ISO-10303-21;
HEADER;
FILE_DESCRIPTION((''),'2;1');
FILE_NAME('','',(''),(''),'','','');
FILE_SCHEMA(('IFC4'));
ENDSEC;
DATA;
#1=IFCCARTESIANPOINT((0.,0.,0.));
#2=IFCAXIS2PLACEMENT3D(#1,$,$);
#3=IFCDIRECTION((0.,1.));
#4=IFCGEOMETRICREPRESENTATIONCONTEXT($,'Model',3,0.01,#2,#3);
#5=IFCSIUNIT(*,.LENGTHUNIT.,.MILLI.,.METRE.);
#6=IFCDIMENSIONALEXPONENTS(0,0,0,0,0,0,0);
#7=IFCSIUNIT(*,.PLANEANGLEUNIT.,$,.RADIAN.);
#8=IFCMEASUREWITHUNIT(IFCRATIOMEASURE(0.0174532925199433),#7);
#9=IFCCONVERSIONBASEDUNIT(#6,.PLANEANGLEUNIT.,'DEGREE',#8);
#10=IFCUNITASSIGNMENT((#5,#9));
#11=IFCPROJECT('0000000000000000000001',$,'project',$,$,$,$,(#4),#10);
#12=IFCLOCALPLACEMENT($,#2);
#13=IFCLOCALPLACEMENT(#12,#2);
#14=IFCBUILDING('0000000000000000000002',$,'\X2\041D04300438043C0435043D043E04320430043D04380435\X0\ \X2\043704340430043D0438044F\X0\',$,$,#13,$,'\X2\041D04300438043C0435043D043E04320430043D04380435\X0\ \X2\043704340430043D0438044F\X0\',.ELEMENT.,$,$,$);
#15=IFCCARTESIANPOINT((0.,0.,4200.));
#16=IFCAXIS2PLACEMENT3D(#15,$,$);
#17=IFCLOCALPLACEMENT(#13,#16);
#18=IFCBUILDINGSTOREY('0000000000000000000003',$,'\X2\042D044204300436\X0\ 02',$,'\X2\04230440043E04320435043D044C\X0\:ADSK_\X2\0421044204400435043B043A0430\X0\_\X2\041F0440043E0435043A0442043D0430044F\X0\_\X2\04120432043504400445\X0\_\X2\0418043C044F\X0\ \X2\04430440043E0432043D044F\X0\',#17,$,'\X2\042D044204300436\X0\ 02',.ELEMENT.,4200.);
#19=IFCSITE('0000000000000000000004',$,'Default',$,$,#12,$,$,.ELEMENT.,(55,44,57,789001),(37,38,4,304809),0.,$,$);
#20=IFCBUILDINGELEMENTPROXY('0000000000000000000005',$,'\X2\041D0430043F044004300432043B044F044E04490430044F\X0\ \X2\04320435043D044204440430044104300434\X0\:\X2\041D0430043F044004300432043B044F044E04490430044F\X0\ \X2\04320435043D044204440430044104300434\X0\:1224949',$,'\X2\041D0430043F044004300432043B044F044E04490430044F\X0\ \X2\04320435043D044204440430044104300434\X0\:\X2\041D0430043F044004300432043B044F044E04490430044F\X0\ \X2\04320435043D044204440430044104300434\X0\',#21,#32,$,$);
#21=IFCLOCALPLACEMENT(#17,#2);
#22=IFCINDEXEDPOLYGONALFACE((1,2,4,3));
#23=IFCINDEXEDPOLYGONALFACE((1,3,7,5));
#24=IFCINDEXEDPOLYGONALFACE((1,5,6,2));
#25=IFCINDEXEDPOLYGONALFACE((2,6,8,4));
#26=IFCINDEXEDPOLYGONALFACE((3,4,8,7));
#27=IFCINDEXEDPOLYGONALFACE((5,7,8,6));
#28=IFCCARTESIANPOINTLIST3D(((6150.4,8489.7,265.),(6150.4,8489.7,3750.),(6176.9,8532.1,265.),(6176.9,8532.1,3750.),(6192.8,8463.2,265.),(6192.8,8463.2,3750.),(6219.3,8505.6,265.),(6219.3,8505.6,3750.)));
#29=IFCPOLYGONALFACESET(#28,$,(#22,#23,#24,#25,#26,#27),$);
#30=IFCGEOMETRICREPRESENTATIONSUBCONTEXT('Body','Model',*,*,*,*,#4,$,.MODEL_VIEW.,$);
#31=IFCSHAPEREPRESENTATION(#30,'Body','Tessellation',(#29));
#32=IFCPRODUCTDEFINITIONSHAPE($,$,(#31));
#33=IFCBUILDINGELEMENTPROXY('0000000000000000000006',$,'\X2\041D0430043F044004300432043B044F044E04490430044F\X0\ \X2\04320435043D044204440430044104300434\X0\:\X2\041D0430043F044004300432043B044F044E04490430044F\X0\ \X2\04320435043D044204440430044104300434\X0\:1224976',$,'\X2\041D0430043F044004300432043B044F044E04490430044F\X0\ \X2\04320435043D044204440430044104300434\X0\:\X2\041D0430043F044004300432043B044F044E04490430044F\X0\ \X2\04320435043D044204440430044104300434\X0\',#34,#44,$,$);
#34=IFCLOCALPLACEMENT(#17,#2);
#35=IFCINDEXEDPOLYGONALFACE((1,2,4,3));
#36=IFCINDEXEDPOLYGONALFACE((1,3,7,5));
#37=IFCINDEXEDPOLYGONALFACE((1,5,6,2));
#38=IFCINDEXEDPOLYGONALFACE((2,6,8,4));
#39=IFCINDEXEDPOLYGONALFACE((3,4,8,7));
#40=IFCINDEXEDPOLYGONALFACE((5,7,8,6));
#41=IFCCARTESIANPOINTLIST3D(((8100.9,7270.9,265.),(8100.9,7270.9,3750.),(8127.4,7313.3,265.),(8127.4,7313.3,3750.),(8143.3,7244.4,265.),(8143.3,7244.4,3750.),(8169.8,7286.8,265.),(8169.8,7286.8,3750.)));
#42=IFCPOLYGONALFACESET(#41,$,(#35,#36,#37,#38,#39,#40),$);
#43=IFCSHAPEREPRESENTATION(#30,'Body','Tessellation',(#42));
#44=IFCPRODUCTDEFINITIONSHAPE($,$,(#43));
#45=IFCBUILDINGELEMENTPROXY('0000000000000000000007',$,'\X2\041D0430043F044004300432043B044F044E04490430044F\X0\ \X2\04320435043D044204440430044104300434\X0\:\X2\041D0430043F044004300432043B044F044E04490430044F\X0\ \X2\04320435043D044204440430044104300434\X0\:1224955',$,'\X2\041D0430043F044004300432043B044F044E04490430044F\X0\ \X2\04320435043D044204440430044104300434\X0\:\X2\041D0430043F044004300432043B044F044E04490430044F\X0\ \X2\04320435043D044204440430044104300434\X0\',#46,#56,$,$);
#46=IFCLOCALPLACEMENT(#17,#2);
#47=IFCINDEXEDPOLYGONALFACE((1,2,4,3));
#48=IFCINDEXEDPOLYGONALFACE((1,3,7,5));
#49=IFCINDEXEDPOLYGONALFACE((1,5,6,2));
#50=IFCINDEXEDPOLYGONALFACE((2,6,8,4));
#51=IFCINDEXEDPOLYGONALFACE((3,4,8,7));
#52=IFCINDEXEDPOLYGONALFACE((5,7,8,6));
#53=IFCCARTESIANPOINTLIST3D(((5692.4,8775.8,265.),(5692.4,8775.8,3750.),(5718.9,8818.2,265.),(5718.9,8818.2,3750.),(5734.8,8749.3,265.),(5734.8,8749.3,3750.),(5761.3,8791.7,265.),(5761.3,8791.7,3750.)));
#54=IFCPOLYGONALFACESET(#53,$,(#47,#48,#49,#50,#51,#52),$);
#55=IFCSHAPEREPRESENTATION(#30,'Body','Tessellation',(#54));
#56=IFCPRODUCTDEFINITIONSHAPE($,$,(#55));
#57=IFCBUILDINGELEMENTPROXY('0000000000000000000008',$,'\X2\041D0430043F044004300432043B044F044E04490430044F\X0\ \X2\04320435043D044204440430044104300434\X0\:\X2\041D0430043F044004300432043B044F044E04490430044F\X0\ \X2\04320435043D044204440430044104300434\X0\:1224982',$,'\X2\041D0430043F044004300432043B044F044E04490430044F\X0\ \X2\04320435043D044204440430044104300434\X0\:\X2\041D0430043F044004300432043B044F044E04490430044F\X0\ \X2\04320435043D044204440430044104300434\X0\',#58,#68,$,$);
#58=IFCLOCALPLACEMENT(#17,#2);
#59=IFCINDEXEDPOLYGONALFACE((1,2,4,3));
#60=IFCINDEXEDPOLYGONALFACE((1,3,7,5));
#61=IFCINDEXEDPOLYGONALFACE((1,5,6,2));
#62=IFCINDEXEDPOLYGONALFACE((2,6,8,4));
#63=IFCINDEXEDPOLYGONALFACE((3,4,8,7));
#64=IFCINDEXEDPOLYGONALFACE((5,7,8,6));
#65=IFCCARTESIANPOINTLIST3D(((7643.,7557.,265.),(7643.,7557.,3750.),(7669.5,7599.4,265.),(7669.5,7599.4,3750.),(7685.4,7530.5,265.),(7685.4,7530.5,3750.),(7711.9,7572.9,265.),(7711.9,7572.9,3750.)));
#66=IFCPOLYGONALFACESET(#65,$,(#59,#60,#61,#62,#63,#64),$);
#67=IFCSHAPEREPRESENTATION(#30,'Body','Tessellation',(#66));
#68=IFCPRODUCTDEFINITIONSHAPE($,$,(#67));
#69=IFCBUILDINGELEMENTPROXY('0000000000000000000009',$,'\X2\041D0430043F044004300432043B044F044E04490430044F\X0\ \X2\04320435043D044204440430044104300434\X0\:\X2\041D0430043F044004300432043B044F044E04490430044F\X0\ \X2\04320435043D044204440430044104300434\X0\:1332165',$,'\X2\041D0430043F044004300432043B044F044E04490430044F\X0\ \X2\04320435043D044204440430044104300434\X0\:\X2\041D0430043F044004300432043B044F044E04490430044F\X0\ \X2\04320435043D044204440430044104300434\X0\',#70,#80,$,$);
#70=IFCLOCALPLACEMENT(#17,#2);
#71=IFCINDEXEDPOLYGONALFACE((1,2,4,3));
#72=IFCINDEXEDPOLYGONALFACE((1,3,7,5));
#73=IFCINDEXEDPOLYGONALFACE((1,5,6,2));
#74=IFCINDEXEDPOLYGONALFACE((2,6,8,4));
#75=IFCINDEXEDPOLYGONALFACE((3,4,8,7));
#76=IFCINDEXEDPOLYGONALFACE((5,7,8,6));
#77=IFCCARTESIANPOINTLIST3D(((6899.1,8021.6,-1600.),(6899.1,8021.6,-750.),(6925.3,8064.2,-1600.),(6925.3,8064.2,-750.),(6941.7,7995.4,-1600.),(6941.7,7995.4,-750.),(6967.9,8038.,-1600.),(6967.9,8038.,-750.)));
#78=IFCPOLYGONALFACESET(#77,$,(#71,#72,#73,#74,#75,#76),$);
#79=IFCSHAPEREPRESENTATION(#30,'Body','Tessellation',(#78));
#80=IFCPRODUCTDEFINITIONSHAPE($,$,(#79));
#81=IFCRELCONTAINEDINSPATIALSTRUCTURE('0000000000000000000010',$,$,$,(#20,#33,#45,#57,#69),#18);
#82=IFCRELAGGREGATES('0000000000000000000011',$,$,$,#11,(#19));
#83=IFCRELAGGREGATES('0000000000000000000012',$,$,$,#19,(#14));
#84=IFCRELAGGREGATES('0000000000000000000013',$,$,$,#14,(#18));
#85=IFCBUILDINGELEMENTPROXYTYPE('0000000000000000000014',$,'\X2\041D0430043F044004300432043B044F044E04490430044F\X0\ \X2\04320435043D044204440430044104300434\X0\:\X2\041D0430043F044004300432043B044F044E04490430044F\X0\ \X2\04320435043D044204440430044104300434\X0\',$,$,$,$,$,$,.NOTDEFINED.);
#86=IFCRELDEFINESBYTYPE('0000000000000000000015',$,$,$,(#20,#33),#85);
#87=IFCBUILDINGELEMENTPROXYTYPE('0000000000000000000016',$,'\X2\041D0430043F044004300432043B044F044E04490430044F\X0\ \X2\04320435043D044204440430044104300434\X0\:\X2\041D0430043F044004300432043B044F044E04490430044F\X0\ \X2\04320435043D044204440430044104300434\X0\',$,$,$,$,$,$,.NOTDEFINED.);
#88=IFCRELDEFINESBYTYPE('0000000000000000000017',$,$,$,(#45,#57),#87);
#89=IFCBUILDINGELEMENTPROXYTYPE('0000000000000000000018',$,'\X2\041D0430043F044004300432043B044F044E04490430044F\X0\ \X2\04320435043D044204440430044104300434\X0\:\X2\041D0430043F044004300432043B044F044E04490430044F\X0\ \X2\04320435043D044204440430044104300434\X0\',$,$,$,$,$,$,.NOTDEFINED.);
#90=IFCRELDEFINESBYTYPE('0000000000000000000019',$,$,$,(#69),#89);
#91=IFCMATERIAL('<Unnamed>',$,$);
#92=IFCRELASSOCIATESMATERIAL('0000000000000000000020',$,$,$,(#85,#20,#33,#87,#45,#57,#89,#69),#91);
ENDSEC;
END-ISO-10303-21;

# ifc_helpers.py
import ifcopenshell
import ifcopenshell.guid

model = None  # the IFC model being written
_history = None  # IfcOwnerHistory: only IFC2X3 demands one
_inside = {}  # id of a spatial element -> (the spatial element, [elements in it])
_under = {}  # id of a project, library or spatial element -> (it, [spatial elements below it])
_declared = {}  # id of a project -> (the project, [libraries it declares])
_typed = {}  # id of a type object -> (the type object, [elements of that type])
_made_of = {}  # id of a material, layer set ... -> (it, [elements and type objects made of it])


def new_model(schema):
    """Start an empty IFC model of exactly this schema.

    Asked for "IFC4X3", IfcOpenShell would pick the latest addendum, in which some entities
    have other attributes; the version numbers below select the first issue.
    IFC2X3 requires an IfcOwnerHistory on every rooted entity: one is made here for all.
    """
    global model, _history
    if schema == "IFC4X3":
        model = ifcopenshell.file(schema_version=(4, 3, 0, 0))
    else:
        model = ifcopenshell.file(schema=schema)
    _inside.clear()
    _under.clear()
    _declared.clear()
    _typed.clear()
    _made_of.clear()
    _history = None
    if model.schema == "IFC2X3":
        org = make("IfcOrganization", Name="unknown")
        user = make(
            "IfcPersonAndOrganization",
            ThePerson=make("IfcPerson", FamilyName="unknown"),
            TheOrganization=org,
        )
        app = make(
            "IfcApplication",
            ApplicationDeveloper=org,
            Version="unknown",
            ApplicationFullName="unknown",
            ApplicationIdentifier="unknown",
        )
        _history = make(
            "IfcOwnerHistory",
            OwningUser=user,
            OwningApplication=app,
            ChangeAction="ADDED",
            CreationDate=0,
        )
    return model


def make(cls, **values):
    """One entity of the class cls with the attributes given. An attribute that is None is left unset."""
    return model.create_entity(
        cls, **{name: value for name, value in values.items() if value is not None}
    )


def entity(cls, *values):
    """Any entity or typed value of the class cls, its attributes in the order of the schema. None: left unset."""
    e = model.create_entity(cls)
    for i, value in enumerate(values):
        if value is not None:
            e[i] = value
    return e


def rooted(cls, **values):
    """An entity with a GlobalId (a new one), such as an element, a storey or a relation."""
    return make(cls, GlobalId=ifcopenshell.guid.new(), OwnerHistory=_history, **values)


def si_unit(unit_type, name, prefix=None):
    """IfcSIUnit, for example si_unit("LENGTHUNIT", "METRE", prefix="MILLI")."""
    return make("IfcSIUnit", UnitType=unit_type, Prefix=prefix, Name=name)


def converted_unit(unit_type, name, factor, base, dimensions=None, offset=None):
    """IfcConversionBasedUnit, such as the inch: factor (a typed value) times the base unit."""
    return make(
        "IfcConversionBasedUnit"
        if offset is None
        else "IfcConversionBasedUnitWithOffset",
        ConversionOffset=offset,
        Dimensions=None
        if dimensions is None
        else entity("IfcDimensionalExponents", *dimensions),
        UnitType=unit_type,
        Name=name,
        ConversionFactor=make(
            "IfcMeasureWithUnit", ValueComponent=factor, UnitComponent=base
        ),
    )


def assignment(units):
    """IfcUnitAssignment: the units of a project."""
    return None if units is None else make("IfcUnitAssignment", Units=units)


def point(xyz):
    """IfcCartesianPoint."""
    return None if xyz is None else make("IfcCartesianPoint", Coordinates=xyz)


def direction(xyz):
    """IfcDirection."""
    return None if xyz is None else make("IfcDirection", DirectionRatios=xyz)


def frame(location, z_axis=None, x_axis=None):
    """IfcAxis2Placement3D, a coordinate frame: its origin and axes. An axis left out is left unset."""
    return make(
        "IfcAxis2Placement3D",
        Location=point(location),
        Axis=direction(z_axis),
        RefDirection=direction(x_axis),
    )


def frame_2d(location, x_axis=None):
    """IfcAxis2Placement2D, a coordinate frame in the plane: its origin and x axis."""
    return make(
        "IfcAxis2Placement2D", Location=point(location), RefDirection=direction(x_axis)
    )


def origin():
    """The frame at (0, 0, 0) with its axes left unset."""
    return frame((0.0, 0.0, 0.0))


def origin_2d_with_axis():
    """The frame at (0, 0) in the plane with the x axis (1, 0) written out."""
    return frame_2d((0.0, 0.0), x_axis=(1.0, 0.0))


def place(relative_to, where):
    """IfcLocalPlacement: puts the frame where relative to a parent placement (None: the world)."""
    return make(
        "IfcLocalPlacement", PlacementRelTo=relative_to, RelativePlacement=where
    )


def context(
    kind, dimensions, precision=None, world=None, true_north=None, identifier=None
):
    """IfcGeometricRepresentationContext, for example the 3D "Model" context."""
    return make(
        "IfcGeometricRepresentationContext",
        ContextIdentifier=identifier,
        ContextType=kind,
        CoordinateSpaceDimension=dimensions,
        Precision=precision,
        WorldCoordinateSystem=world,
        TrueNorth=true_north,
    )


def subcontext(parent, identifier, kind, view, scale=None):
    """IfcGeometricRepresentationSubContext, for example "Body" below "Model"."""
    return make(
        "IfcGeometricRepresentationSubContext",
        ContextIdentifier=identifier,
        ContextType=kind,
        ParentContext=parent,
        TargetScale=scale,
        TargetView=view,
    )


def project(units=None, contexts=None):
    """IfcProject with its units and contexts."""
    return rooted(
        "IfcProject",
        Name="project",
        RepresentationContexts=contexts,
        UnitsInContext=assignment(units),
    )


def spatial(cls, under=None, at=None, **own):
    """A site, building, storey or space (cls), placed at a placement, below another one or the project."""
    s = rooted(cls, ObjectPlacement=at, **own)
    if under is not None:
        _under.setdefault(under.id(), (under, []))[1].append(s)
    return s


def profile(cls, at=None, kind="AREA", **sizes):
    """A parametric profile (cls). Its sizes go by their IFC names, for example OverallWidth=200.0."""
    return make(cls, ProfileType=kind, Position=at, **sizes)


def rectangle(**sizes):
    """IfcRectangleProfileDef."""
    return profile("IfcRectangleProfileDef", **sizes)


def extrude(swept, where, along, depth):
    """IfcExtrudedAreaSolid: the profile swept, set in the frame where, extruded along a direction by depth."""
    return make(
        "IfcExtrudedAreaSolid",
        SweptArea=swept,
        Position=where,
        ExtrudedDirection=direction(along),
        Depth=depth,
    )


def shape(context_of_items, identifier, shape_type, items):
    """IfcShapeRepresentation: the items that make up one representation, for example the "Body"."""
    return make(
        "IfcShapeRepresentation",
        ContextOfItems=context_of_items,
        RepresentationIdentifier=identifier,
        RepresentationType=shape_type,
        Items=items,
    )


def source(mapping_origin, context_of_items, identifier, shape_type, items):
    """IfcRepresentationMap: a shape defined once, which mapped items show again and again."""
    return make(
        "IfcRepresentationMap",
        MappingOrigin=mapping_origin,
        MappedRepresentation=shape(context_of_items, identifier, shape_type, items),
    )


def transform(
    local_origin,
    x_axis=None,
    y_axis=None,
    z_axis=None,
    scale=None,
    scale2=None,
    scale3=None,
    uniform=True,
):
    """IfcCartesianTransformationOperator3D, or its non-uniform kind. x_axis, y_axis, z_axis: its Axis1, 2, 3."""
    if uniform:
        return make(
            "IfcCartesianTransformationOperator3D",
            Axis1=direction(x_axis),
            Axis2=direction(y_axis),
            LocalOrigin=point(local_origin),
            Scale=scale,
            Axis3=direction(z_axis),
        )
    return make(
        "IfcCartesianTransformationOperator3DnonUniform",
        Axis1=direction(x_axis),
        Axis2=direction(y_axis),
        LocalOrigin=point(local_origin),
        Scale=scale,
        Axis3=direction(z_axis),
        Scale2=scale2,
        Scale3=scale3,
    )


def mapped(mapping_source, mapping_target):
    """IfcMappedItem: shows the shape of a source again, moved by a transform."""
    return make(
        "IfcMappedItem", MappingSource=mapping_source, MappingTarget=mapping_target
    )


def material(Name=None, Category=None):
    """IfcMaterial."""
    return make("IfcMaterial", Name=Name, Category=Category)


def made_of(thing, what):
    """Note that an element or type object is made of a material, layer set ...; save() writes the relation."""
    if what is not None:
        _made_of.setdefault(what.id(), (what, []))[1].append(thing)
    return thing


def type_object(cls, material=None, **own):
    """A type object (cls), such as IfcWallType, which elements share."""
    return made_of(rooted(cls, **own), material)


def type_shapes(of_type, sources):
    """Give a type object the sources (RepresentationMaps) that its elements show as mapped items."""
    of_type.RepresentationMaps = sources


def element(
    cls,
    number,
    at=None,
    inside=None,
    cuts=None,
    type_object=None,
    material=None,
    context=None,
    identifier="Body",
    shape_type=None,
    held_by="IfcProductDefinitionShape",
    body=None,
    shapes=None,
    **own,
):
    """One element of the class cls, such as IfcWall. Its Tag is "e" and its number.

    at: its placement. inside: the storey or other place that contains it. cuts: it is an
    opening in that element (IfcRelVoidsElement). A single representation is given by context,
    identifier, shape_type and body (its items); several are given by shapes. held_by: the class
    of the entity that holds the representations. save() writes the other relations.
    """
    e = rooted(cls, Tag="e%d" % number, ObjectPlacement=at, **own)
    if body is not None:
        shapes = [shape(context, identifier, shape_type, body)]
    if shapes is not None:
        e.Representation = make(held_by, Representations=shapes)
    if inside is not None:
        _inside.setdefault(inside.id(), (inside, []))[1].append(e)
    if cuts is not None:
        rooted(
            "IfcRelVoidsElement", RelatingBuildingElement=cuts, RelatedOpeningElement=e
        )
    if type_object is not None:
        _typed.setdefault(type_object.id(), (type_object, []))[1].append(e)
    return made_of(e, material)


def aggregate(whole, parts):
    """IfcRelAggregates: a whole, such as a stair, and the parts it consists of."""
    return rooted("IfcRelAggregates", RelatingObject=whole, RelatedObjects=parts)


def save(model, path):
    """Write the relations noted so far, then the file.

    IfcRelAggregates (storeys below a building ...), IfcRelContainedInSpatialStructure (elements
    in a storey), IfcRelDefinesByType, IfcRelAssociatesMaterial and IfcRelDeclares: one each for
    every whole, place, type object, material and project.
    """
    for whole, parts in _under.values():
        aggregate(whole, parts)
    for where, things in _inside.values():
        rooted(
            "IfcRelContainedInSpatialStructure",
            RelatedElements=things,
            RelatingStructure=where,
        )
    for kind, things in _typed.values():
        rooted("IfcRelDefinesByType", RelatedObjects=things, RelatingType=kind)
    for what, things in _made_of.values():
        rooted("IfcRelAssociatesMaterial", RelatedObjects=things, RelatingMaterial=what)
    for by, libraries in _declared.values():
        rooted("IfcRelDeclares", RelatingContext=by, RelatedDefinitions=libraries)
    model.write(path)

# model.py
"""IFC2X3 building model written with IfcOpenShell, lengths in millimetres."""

from ifc_helpers import new_model, entity, si_unit, converted_unit, direction, frame, origin, origin_2d_with_axis, place, context, subcontext, project, spatial, rectangle, extrude, source, transform, mapped, material, type_object, type_shapes, element, save


model = new_model("IFC2X3")

# Units and contexts
model_context = context("Model", 3, precision=0.01, world=origin(), true_north=direction((0.0, 1.0)))
body_context = subcontext(model_context, "Body", "Model", "MODEL_VIEW")
ifc_project = project(units=[si_unit("LENGTHUNIT", "METRE", prefix="MILLI"), converted_unit("PLANEANGLEUNIT", "DEGREE", entity("IfcRatioMeasure", 0.0174532925199433), si_unit("PLANEANGLEUNIT", "RADIAN"), dimensions=[0, 0, 0, 0, 0, 0, 0])], contexts=[model_context])

# Site, building, storey
site_placement = place(None, origin())
site = spatial("IfcSite", under=ifc_project, at=site_placement, Name="Default", CompositionType="ELEMENT", RefLatitude=(55, 44, 57, 789001), RefLongitude=(37, 38, 4, 304809), RefElevation=0.0)
building_placement = place(site_placement, origin())
building = spatial("IfcBuilding", under=site, at=building_placement, Name="Наименование здания", LongName="Наименование здания", CompositionType="ELEMENT")
storey_placement = place(building_placement, frame((0.0, 0.0, 4200.0)))
storey = spatial("IfcBuildingStorey", under=building, at=storey_placement, Name="Этаж 02", ObjectType="Уровень:ADSK_Стрелка_Проектная_Вверх_Имя уровня", LongName="Этаж 02", CompositionType="ELEMENT", Elevation=4200.0)

# Building element proxies
ifc_material_1 = material(Name="<Unnamed>")
building_element_proxy_type_1 = type_object("IfcBuildingElementProxyType", Name="Направляющая вентфасад:Направляющая вентфасад", PredefinedType="NOTDEFINED", material=ifc_material_1)
shared_shape_1 = source(origin(), body_context, "Body", "SweptSolid", [
    extrude(rectangle(XDim=50.0, YDim=50.0, at=origin_2d_with_axis()), frame((25.0, -25.0, 0.0), z_axis=(0.0, 0.0, 1.0), x_axis=(-1.0, 0.0, 0.0)), (0.0, 0.0, 1.0), 3485.0),
])
type_shapes(building_element_proxy_type_1, [shared_shape_1])
for number, where, z_axis, x_axis, name in (
    (1, (6176.9, 8532.1, 265.0), (0.0, 0.0, 1.0), (0.848053, -0.529912, 0.0), "Направляющая вентфасад:Направляющая вентфасад:1224949"),
    (2, (8127.4, 7313.3, 265.0), (0.0, 0.0, 1.0), (0.848053, -0.529912, 0.0), "Направляющая вентфасад:Направляющая вентфасад:1224976"),
):
    element("IfcBuildingElementProxy", number, at=place(storey_placement, frame(where, z_axis=z_axis, x_axis=x_axis)), inside=storey, type_object=building_element_proxy_type_1, material=ifc_material_1, Name=name, ObjectType="Направляющая вентфасад:Направляющая вентфасад", context=body_context, shape_type="MappedRepresentation", body=[
        mapped(shared_shape_1, transform((0.0, 0.0, 0.0), scale=1.0)),
    ])
building_element_proxy_type_2 = type_object("IfcBuildingElementProxyType", Name="Направляющая вентфасад:Направляющая вентфасад", PredefinedType="NOTDEFINED", material=ifc_material_1)
shared_shape_2 = source(origin(), body_context, "Body", "SweptSolid", [
    extrude(rectangle(XDim=50.0, YDim=50.0, at=origin_2d_with_axis()), frame((25.0, 25.0, 0.0), z_axis=(0.0, 0.0, 1.0), x_axis=(0.0, 1.0, 0.0)), (0.0, 0.0, 1.0), 3485.0),
])
type_shapes(building_element_proxy_type_2, [shared_shape_2])
for number, where, z_axis, x_axis, name in (
    (3, (5761.3, 8791.7, 265.0), (0.0, 0.0, 1.0), (-0.848053, 0.529912, 0.0), "Направляющая вентфасад:Направляющая вентфасад:1224955"),
    (4, (7711.9, 7572.9, 265.0), (0.0, 0.0, 1.0), (-0.848053, 0.529912, 0.0), "Направляющая вентфасад:Направляющая вентфасад:1224982"),
):
    element("IfcBuildingElementProxy", number, at=place(storey_placement, frame(where, z_axis=z_axis, x_axis=x_axis)), inside=storey, type_object=building_element_proxy_type_2, material=ifc_material_1, Name=name, ObjectType="Направляющая вентфасад:Направляющая вентфасад", context=body_context, shape_type="MappedRepresentation", body=[
        mapped(shared_shape_2, transform((0.0, 0.0, 0.0), scale=1.0)),
    ])
building_element_proxy_type_3 = type_object("IfcBuildingElementProxyType", Name="Направляющая вентфасад:Направляющая вентфасад", PredefinedType="NOTDEFINED", material=ifc_material_1)
shared_shape_3 = source(origin(), body_context, "Body", "SweptSolid", [
    extrude(rectangle(XDim=50.0, YDim=50.0, at=origin_2d_with_axis()), frame((25.0, 25.0, 0.0), z_axis=(0.0, 0.0, 1.0), x_axis=(0.0, 1.0, 0.0)), (0.0, 0.0, 1.0), 850.0),
])
type_shapes(building_element_proxy_type_3, [shared_shape_3])
proxy_1_placement = place(storey_placement, frame((6967.9, 8038.0, -1600.0), z_axis=(0.0, 0.0, 1.0), x_axis=(-0.85195, 0.523622, 0.0)))
element("IfcBuildingElementProxy", 5, at=proxy_1_placement, inside=storey, type_object=building_element_proxy_type_3, material=ifc_material_1, Name="Направляющая вентфасад:Направляющая вентфасад:1332165", ObjectType="Направляющая вентфасад:Направляющая вентфасад", context=body_context, shape_type="MappedRepresentation", body=[
    mapped(shared_shape_3, transform((0.0, 0.0, 0.0), scale=1.0)),
])

save(model, "model.ifc")
